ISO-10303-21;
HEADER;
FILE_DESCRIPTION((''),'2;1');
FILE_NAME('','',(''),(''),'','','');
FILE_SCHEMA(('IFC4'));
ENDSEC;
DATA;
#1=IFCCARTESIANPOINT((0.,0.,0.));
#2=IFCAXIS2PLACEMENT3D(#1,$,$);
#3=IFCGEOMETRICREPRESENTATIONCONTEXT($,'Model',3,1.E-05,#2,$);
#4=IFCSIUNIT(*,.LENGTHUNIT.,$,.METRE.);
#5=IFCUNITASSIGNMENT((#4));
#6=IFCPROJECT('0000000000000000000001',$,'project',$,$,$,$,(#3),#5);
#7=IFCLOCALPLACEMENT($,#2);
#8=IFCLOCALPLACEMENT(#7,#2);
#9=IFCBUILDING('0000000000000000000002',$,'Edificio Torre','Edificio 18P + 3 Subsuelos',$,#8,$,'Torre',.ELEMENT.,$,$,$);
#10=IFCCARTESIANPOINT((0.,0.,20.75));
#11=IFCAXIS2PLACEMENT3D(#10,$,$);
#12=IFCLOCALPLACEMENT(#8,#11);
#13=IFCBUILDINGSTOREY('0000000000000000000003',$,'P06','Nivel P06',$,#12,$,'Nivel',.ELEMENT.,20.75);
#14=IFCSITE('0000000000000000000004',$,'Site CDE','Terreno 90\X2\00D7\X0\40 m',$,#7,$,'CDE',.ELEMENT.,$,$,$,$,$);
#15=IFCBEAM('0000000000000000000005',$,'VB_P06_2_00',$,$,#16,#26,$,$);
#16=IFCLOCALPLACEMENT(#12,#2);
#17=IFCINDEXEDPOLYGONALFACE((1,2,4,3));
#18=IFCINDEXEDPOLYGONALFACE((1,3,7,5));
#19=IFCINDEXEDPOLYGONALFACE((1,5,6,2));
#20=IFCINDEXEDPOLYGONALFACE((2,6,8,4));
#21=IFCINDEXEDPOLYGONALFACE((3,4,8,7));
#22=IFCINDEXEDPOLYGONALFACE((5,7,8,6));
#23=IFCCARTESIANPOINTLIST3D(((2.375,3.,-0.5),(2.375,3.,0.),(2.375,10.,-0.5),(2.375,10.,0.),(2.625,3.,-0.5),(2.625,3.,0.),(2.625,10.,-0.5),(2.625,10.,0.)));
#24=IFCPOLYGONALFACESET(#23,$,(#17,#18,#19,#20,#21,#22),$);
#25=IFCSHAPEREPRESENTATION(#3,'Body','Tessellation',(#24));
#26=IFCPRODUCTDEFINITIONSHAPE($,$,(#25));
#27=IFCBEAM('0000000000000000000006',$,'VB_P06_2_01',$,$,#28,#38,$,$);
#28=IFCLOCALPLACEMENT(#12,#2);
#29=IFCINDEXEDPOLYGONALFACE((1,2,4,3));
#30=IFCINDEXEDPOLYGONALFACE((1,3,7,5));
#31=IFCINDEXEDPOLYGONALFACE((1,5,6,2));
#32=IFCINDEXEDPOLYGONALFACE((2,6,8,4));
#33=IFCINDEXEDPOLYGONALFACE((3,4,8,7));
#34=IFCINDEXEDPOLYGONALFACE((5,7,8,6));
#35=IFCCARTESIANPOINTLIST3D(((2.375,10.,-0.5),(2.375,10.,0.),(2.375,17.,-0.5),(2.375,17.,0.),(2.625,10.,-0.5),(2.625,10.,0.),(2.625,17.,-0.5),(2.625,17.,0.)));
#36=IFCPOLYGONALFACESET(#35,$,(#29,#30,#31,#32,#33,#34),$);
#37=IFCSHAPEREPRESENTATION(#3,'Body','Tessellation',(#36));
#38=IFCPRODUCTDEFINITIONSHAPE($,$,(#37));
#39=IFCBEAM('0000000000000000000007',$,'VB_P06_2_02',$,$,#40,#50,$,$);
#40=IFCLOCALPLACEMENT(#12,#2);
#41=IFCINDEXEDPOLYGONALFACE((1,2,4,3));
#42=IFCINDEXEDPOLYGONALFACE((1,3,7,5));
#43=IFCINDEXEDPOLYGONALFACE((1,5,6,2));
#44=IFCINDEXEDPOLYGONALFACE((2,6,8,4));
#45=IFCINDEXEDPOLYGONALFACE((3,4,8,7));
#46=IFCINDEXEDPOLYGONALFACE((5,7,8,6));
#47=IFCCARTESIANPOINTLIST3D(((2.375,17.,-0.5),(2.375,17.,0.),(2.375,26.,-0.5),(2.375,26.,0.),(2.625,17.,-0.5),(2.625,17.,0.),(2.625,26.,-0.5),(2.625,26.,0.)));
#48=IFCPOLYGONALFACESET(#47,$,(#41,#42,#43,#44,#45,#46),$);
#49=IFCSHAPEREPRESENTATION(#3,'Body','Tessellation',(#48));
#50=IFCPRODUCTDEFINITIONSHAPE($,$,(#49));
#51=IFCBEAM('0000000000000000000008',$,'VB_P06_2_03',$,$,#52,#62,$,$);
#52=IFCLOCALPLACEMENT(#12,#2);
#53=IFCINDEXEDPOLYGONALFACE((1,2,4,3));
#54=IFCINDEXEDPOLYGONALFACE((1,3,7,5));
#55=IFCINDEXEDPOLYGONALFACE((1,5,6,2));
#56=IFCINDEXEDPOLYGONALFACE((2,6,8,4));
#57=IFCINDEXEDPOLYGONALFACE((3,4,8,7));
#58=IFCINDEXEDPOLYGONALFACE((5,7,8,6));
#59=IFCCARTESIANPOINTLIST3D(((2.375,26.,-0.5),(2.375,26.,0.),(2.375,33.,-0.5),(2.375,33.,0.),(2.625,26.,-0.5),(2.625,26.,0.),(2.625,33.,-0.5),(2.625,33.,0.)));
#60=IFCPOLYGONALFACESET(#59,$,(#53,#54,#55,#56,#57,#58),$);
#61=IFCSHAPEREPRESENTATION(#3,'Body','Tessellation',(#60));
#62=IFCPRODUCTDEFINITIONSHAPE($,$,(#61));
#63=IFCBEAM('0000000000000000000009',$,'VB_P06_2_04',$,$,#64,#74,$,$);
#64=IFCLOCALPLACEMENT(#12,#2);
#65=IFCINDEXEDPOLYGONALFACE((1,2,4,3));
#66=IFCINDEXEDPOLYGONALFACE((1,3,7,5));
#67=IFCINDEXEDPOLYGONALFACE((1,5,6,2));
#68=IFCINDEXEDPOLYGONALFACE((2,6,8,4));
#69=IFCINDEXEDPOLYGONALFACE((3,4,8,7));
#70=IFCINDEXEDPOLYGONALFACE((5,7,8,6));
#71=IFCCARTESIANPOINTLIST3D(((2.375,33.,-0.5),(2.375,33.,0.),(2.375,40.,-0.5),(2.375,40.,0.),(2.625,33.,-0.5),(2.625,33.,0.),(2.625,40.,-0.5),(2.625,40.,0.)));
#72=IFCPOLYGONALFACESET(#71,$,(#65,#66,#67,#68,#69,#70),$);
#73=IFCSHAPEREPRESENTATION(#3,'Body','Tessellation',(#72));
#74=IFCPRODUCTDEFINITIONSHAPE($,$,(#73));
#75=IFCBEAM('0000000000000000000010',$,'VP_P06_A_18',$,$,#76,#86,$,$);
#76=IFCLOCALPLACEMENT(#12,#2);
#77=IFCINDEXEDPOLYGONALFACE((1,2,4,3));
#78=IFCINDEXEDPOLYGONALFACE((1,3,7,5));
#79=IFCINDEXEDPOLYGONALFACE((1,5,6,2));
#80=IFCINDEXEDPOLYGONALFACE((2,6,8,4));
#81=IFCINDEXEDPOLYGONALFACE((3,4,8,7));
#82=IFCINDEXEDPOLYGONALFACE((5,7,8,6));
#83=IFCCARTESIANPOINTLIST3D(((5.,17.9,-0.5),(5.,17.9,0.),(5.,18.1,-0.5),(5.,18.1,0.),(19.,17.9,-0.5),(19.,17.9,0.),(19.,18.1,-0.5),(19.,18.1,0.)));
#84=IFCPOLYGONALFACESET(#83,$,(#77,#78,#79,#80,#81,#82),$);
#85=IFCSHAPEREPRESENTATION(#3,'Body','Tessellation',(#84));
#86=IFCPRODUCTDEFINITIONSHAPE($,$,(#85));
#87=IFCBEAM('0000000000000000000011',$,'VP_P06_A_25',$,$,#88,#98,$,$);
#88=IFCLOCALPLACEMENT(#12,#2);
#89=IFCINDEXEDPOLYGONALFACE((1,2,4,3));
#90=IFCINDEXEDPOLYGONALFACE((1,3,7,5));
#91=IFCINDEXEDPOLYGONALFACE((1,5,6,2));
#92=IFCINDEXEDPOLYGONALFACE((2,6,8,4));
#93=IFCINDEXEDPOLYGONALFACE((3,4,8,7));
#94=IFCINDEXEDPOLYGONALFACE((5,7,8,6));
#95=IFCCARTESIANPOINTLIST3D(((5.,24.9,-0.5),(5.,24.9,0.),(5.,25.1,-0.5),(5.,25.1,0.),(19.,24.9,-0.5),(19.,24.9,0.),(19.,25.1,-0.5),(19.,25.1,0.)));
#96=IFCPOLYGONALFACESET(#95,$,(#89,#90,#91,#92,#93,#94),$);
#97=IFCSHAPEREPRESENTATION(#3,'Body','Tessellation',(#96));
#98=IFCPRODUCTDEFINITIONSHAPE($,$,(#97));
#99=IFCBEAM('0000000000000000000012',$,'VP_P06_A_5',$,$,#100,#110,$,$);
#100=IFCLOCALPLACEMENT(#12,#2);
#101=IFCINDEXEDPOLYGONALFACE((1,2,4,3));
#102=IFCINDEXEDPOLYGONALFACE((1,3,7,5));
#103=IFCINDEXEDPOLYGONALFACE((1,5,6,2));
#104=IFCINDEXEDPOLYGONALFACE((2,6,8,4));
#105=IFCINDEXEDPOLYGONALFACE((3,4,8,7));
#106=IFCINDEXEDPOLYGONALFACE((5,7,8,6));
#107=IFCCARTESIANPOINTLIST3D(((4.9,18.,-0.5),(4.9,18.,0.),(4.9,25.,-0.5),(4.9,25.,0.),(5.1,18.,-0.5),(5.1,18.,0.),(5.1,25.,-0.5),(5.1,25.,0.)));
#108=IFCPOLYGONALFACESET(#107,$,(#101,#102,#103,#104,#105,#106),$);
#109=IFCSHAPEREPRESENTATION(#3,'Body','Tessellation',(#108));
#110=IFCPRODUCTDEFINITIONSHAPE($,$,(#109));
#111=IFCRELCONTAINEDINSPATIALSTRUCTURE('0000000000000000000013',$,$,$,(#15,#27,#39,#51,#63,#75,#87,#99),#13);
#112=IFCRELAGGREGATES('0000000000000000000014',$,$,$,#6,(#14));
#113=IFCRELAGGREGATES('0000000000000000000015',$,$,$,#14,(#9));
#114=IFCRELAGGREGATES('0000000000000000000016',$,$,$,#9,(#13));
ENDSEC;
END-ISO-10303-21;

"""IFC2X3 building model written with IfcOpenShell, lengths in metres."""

from ifc_helpers import new_model, si_unit, frame, origin, origin_2d, place, context, project, spatial, rectangle, extrude, element, save


model = new_model("IFC2X3")

# Units and contexts
model_context = context("Model", 3, precision=1e-05, world=origin())
ifc_project = project(units=[si_unit("LENGTHUNIT", "METRE")], contexts=[model_context])

# Site, building, storey
site_placement = place(None, origin())
site = spatial("IfcSite", under=ifc_project, at=site_placement, Name="Site CDE", Description="Terreno 90×40 m", LongName="CDE", CompositionType="ELEMENT")
building_placement = place(site_placement, origin())
building = spatial("IfcBuilding", under=site, at=building_placement, Name="Edificio Torre", Description="Edificio 18P + 3 Subsuelos", LongName="Torre", CompositionType="ELEMENT")
storey_placement = place(building_placement, frame((0.0, 0.0, 20.75)))
storey = spatial("IfcBuildingStorey", under=building, at=storey_placement, Name="P06", Description="Nivel P06", LongName="Nivel", CompositionType="ELEMENT", Elevation=20.75)

# Beams
for number, where, name in (
    (1, (2.5, 6.5, -0.5), "VB_P06_2_00"),
    (2, (2.5, 13.5, -0.5), "VB_P06_2_01"),
):
    element("IfcBeam", number, at=place(storey_placement, frame(where)), inside=storey, Name=name, context=model_context, shape_type="SweptSolid", body=[
        extrude(rectangle(XDim=0.25, YDim=7.0, at=origin_2d()), origin(), (0.0, 0.0, 1.0), 0.5),
    ])
beam_1_placement = place(storey_placement, frame((2.5, 21.5, -0.5)))
element("IfcBeam", 3, at=beam_1_placement, inside=storey, Name="VB_P06_2_02", context=model_context, shape_type="SweptSolid", body=[
    extrude(rectangle(XDim=0.25, YDim=9.0, at=origin_2d()), origin(), (0.0, 0.0, 1.0), 0.5),
])
for number, where, name in (
    (4, (2.5, 29.5, -0.5), "VB_P06_2_03"),
    (5, (2.5, 36.5, -0.5), "VB_P06_2_04"),
):
    element("IfcBeam", number, at=place(storey_placement, frame(where)), inside=storey, Name=name, context=model_context, shape_type="SweptSolid", body=[
        extrude(rectangle(XDim=0.25, YDim=7.0, at=origin_2d()), origin(), (0.0, 0.0, 1.0), 0.5),
    ])
for number, where, name in (
    (6, (12.0, 18.0, -0.5), "VP_P06_A_18"),
    (7, (12.0, 25.0, -0.5), "VP_P06_A_25"),
):
    element("IfcBeam", number, at=place(storey_placement, frame(where)), inside=storey, Name=name, context=model_context, shape_type="SweptSolid", body=[
        extrude(rectangle(XDim=14.0, YDim=0.2, at=origin_2d()), origin(), (0.0, 0.0, 1.0), 0.5),
    ])
beam_2_placement = place(storey_placement, frame((5.0, 21.5, -0.5)))
element("IfcBeam", 8, at=beam_2_placement, inside=storey, Name="VP_P06_A_5", context=model_context, shape_type="SweptSolid", body=[
    extrude(rectangle(XDim=0.2, YDim=7.0, at=origin_2d()), origin(), (0.0, 0.0, 1.0), 0.5),
])

save(model, "model.ifc")
